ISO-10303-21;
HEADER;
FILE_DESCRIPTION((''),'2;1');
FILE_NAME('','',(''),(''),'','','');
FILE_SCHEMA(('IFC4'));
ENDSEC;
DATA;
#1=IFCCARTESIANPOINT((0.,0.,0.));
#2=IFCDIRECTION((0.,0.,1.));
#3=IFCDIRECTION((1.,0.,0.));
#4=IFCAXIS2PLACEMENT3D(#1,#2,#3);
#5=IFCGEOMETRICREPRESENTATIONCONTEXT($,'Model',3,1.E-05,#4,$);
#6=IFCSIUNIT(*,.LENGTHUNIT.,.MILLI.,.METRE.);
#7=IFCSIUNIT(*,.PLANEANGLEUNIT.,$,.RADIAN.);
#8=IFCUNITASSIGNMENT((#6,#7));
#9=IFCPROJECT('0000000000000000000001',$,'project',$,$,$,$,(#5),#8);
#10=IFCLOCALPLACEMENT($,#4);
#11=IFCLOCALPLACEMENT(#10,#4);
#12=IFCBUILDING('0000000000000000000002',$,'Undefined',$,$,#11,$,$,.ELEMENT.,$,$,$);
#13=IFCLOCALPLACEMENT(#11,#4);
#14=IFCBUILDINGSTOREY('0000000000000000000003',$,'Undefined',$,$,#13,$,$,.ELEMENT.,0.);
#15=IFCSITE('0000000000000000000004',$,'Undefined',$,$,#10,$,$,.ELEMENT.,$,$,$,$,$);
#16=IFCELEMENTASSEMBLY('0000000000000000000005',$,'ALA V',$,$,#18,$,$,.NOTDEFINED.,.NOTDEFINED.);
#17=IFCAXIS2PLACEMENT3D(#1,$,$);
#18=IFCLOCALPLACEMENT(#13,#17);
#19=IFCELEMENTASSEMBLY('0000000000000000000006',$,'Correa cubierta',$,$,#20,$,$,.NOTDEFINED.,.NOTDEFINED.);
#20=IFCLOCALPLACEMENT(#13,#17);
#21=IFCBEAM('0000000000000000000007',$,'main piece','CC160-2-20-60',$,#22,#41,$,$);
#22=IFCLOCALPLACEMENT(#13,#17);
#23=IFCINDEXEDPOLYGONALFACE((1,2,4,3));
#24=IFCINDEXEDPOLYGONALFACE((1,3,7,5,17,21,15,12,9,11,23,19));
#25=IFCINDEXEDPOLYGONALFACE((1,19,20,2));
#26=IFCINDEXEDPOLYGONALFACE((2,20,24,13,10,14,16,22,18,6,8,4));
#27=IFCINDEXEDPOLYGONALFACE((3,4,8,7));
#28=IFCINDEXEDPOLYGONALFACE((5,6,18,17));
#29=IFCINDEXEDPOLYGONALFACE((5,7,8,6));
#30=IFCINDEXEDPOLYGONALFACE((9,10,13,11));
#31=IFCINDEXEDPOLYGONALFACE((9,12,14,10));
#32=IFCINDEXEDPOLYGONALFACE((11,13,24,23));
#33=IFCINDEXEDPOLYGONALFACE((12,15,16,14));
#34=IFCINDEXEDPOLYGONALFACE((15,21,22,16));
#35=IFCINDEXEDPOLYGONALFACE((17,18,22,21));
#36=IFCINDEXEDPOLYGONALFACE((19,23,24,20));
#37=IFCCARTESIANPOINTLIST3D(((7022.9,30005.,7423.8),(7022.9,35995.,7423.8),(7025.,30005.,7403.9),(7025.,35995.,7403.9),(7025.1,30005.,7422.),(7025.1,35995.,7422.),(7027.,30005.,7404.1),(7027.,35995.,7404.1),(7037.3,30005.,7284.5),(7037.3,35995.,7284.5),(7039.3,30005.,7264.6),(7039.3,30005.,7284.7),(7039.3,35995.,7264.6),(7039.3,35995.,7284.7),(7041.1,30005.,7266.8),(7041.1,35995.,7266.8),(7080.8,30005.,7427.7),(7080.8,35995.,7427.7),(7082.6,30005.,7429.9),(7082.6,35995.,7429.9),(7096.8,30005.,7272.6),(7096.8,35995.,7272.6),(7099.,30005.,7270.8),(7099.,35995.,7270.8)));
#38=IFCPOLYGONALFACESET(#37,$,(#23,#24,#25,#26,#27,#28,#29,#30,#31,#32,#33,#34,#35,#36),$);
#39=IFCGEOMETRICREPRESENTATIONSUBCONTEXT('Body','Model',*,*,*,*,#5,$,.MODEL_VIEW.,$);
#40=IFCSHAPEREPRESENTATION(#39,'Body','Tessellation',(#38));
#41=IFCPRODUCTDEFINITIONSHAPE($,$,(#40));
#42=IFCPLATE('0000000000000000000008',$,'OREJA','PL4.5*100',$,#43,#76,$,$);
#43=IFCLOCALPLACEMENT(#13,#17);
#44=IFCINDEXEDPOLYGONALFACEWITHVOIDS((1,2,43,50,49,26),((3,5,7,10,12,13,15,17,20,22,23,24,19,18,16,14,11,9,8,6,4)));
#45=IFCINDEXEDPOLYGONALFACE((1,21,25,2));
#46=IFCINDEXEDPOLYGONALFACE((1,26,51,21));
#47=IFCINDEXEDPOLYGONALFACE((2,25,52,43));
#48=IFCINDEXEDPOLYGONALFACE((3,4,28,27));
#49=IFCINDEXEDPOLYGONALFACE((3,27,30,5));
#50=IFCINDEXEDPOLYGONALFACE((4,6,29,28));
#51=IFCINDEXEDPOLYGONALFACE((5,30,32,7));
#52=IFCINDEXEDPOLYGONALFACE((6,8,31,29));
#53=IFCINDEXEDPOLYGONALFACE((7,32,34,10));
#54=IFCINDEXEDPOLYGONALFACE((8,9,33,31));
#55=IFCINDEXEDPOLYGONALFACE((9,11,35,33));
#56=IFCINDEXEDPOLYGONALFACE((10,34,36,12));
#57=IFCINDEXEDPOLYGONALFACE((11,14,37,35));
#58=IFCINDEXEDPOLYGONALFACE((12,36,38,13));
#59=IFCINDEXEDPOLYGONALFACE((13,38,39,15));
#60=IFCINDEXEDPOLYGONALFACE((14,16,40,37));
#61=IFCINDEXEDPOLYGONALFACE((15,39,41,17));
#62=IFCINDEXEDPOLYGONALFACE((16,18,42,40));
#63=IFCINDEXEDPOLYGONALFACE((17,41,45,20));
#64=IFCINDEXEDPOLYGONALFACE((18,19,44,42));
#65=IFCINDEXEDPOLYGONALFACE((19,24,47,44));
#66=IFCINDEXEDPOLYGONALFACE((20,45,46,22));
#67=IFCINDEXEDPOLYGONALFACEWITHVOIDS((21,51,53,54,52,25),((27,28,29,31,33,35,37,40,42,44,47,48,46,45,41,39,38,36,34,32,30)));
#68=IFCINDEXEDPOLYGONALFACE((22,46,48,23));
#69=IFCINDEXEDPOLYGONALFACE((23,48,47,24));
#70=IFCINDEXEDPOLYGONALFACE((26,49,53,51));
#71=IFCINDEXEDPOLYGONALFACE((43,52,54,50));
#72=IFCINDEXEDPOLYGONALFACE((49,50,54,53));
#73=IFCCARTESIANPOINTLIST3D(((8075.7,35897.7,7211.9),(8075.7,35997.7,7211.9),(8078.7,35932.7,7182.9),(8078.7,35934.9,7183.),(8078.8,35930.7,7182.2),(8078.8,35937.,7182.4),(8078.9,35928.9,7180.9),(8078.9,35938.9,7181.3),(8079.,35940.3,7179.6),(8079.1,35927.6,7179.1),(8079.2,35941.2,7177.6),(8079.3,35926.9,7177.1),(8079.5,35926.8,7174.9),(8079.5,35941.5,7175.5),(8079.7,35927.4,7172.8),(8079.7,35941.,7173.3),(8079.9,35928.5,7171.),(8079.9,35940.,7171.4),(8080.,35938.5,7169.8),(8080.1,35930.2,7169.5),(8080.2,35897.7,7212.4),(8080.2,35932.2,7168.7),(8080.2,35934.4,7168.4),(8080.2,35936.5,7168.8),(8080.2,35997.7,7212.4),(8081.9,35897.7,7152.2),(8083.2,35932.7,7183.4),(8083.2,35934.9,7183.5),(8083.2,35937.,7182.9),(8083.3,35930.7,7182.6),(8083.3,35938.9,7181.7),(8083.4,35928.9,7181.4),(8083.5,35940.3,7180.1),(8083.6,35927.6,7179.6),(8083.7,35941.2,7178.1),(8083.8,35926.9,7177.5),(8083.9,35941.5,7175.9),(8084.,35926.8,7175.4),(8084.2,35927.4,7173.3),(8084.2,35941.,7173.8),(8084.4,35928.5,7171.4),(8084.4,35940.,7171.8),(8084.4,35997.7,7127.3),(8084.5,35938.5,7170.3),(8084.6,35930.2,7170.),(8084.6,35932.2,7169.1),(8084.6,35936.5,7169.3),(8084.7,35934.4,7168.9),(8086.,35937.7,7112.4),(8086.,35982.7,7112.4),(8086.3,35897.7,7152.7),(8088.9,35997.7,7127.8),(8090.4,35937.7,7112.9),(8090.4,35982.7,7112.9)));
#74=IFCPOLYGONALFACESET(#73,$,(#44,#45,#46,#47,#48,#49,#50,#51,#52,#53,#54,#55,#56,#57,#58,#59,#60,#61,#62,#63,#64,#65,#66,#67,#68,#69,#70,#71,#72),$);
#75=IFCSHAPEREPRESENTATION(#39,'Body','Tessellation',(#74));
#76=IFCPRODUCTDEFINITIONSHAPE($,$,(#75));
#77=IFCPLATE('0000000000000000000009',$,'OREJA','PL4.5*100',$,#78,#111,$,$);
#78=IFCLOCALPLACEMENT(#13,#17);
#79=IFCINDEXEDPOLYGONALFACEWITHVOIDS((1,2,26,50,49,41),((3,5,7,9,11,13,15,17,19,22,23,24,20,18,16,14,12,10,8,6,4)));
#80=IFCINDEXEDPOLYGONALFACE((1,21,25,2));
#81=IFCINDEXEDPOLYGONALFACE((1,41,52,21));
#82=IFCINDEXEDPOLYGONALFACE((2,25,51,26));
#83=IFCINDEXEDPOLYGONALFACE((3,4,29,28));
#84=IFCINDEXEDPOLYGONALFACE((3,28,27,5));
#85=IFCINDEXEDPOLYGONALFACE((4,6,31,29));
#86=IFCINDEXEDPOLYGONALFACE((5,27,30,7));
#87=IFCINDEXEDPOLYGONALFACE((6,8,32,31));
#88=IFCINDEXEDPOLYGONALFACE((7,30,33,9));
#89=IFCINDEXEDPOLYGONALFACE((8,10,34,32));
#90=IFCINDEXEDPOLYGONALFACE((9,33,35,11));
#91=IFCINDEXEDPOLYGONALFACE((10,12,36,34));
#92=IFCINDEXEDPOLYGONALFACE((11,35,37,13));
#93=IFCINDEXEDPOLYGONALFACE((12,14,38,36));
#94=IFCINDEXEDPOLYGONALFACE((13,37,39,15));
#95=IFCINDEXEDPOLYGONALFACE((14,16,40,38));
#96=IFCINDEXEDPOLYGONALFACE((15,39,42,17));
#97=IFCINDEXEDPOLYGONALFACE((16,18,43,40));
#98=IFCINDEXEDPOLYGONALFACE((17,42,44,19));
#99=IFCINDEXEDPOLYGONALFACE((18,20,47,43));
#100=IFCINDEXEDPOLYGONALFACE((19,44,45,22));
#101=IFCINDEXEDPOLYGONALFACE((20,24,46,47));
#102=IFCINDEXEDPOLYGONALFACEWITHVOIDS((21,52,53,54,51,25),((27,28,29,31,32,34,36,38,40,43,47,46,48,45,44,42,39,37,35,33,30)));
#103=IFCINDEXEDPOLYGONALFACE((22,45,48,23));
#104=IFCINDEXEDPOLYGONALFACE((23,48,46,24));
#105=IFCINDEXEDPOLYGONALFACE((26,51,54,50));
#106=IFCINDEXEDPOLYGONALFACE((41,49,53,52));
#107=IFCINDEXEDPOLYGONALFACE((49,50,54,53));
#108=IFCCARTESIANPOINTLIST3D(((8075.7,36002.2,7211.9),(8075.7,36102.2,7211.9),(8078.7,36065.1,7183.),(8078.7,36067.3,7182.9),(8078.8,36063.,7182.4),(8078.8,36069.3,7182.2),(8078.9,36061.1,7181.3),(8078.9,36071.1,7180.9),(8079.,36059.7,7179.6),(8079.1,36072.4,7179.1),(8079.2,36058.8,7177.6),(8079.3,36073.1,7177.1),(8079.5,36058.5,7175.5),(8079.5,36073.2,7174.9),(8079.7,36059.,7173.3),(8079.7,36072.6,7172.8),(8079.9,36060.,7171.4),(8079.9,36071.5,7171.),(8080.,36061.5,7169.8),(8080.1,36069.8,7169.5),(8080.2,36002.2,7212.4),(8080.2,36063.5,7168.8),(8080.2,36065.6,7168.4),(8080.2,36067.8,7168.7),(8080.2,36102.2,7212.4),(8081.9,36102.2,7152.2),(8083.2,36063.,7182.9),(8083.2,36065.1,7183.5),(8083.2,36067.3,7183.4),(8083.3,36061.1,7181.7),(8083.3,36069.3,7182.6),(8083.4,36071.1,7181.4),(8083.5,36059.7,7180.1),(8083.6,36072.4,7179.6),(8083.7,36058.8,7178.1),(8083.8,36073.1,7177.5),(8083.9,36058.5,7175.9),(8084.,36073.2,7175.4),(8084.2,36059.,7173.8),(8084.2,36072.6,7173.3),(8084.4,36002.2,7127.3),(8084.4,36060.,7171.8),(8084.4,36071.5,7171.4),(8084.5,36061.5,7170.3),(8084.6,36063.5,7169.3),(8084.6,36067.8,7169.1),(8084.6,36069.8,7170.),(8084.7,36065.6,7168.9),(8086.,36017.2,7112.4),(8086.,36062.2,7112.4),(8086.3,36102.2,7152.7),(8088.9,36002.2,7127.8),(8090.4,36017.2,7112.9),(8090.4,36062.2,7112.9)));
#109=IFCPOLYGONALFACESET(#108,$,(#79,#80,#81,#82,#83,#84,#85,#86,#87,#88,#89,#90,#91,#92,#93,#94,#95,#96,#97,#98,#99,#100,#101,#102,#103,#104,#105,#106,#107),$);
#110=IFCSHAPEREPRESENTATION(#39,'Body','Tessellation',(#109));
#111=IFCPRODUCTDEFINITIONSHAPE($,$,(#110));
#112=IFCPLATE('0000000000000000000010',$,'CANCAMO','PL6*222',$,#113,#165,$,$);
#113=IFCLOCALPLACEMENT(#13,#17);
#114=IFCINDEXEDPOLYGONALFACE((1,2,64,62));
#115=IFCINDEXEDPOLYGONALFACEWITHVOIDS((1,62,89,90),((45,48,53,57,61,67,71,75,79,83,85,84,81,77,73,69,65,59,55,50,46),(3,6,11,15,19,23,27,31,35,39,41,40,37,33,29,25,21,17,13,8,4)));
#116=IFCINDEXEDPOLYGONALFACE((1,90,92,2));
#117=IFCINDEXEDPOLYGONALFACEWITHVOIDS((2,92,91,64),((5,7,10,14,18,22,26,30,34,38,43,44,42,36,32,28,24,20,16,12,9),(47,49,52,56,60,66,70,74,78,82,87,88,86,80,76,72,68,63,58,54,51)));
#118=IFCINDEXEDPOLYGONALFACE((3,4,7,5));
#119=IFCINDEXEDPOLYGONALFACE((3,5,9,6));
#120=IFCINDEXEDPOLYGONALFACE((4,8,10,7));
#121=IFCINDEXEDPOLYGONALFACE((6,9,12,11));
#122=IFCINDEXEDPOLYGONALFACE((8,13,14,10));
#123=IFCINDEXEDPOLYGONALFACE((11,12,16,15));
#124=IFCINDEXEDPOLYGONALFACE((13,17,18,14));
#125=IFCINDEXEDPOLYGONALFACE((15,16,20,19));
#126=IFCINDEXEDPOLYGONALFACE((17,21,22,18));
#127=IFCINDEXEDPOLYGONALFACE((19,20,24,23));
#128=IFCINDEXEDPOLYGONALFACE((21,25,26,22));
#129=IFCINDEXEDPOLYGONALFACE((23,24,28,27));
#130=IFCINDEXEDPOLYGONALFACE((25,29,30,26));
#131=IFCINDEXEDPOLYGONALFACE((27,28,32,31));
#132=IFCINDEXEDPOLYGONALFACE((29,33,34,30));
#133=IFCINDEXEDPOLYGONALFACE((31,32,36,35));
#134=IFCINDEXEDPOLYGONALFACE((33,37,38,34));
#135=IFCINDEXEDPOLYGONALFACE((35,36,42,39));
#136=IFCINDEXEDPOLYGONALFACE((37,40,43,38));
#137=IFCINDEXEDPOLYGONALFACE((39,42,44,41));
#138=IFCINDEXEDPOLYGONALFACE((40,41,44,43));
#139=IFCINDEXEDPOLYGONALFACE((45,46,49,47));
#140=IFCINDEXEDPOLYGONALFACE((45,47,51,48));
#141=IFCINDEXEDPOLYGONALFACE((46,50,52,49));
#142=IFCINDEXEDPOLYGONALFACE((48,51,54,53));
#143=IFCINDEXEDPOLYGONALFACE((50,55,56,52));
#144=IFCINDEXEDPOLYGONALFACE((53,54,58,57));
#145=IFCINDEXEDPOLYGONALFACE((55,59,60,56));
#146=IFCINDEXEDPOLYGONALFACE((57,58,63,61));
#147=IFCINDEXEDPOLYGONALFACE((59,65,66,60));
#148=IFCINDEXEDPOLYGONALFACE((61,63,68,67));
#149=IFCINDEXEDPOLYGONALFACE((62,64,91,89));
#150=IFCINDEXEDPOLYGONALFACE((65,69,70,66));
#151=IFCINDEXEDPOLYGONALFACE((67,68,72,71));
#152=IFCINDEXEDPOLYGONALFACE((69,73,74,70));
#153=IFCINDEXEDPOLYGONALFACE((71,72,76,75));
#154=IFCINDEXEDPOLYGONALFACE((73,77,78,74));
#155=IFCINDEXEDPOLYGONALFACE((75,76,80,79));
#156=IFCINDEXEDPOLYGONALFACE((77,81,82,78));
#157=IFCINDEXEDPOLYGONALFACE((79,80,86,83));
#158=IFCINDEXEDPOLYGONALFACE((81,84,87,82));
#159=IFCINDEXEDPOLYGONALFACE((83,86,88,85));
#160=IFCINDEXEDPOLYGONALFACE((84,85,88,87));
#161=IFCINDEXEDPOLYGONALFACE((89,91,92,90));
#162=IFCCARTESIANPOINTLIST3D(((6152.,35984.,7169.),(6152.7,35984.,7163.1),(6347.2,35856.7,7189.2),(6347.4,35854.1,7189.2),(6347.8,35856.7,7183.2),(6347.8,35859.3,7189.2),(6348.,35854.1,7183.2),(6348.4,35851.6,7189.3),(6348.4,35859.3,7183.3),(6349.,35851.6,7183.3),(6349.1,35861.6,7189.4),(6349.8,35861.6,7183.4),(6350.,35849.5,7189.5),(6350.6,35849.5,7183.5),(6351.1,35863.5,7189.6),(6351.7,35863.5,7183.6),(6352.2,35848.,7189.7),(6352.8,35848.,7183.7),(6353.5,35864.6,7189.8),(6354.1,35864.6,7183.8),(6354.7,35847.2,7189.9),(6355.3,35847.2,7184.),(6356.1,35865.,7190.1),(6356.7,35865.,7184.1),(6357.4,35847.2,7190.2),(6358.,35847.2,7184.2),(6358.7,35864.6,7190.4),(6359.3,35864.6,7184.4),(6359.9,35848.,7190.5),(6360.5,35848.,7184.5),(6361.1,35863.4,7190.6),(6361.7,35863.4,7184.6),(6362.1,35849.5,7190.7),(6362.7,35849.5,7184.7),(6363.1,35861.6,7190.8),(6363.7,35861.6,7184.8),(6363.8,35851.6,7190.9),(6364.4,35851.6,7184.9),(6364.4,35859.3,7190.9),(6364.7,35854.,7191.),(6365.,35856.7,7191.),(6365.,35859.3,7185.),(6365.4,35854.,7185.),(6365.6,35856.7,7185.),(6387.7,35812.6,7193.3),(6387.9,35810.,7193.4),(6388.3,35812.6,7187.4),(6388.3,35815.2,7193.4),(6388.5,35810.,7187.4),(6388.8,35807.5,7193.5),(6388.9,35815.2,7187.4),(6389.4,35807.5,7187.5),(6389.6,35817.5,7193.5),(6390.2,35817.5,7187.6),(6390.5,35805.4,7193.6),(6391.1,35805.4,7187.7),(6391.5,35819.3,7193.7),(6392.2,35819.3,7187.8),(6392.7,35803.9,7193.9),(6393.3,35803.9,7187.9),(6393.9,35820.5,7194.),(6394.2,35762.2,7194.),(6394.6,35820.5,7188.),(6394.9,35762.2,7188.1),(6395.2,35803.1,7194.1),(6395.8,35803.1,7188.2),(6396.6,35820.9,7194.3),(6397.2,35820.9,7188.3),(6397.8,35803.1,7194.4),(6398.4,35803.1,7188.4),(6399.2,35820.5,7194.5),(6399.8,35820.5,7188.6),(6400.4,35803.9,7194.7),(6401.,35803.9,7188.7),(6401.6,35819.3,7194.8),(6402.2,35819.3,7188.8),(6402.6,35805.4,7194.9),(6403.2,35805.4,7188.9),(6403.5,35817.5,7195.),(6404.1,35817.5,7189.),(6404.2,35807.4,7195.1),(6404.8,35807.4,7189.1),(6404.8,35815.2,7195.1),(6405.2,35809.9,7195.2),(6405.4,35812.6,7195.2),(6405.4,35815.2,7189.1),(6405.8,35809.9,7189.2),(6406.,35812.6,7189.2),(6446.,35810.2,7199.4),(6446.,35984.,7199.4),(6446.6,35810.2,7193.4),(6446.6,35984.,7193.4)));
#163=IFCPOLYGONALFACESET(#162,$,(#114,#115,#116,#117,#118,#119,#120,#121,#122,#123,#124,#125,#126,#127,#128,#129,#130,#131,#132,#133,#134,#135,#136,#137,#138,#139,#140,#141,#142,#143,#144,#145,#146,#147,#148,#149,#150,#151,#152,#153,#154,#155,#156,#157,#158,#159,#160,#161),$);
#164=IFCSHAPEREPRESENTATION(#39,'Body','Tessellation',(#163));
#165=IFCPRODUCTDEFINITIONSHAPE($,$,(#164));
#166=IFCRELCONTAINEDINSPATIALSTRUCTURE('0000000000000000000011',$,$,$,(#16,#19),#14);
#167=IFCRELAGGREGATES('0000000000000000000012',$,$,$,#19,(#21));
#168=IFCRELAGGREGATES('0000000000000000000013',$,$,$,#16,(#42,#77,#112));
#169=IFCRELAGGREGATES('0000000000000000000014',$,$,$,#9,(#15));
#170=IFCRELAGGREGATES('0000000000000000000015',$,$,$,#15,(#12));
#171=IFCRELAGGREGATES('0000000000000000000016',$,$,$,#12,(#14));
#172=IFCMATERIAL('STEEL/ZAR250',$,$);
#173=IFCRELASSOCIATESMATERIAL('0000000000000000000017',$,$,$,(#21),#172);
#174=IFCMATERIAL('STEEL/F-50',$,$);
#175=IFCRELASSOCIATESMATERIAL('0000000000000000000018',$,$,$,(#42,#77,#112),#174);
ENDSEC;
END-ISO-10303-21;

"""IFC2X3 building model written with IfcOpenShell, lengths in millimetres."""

from ifc_helpers import new_model, si_unit, frame, origin_with_axes, origin_2d_with_axis, place, context, subcontext, project, spatial, polyline, circle, c_section, outline, extrude, source, transform, mapped, material, element, aggregate, save


model = new_model("IFC2X3")

# Units and contexts
model_context = context("Model", 3, precision=1e-05, world=origin_with_axes())
body_context = subcontext(model_context, "Body", "Model", "MODEL_VIEW")
ifc_project = project(units=[si_unit("LENGTHUNIT", "METRE", prefix="MILLI"), si_unit("PLANEANGLEUNIT", "RADIAN")], contexts=[model_context])

# Site, building, storey
site_placement = place(None, origin_with_axes())
site = spatial("IfcSite", under=ifc_project, at=site_placement, Name="Undefined", CompositionType="ELEMENT")
building_placement = place(site_placement, origin_with_axes())
building = spatial("IfcBuilding", under=site, at=building_placement, Name="Undefined", CompositionType="ELEMENT")
storey_placement = place(building_placement, origin_with_axes())
storey = spatial("IfcBuildingStorey", under=building, at=storey_placement, Name="Undefined", CompositionType="ELEMENT", Elevation=0.0)

# Element assembly
assembly_1_placement = place(storey_placement, origin_with_axes())
assembly_1 = element("IfcElementAssembly", 1, at=assembly_1_placement, inside=storey, Name="ALA V", AssemblyPlace="NOTDEFINED", PredefinedType="NOTDEFINED")
ifc_material_1 = material(Name="STEEL/F-50")

# Element assembly, beam
ifc_material_2 = material(Name="STEEL/ZAR250")
assembly_2_placement = place(storey_placement, origin_with_axes())
assembly_2 = element("IfcElementAssembly", 2, at=assembly_2_placement, inside=storey, Name="Correa cubierta", AssemblyPlace="NOTDEFINED", PredefinedType="NOTDEFINED")
beam_1_placement = place(assembly_2_placement, frame((7061.0, 35995.0, 7347.3), z_axis=(-0.102562, 0.0, 0.994727), x_axis=(0.0, -1.0, 0.0)))
beam_1 = element("IfcBeam", 3, at=beam_1_placement, material=ifc_material_2, Name="main piece", Description="CC160-2-20-60", context=body_context, shape_type="SweptSolid", body=[
    extrude(c_section(Depth=160.0, Width=60.0, WallThickness=2.0, Girth=20.0, at=origin_2d_with_axis()), frame((5990.0, 0.0, 0.0), z_axis=(-1.0, 0.0, 0.0), x_axis=(0.0, -1.0, 0.0)), (0.0, 0.0, 1.0), 5990.0),
])
aggregate(assembly_2, [beam_1])

# Plates, openings
plate_1_placement = place(assembly_1_placement, frame((8088.2, 35997.7, 7112.7), z_axis=(-0.994727, 0.0, -0.102562), x_axis=(0.0, -1.0, 0.0)))
plate_1 = element("IfcPlate", 4, at=plate_1_placement, material=ifc_material_1, Name="OREJA", Description="PL4.5*100", context=body_context, shape_type="SweptSolid", body=[
    extrude(outline(polyline([(0.0, 15.0), (15.0, 0.0), (60.0, 0.0), (100.0, 40.0), (100.0, 100.0), (0.0, 100.0), (0.0, 15.0)])), frame((0.0, 0.0, -2.2), z_axis=(0.0, 0.0, 1.0), x_axis=(1.0, 0.0, 0.0)), (0.0, 0.0, 1.0), 4.5),
])
shared_shape_1 = source(origin_with_axes(), body_context, "Body", "SweptSolid", [
    extrude(circle(Radius=7.3, at=origin_2d_with_axis()), frame((0.0, -0.1, 0.0), z_axis=(0.0, 1.0, 0.0), x_axis=(1.0, 0.0, 0.0)), (0.0, 0.0, 1.0), 4.7),
])
opening_1_placement = place(assembly_1_placement, frame((8083.9, 35934.1, 7176.2), z_axis=(0.072522, -0.707107, -0.703378), x_axis=(-0.072522, -0.707107, 0.703378)))
element("IfcOpeningElement", 5, at=opening_1_placement, cuts=plate_1, ObjectType="Opening", context=body_context, shape_type="MappedRepresentation", body=[
    mapped(shared_shape_1, transform((0.0, 0.0, 0.0))),
])
plate_2_placement = place(assembly_1_placement, frame((8088.2, 36002.2, 7112.7), z_axis=(0.994727, 0.0, 0.102562), x_axis=(0.0, 1.0, 0.0)))
plate_2 = element("IfcPlate", 6, at=plate_2_placement, material=ifc_material_1, Name="OREJA", Description="PL4.5*100", context=body_context, shape_type="SweptSolid", body=[
    extrude(outline(polyline([(0.0, 15.0), (15.0, 0.0), (60.0, 0.0), (100.0, 40.0), (100.0, 100.0), (0.0, 100.0), (0.0, 15.0)])), frame((0.0, 0.0, -2.2), z_axis=(0.0, 0.0, 1.0), x_axis=(1.0, 0.0, 0.0)), (0.0, 0.0, 1.0), 4.5),
])
opening_2_placement = place(assembly_1_placement, frame((8083.9, 36065.9, 7176.2), z_axis=(-0.072522, -0.707107, 0.703378), x_axis=(-0.072522, 0.707107, 0.703378)))
element("IfcOpeningElement", 7, at=opening_2_placement, cuts=plate_2, ObjectType="Opening", context=body_context, shape_type="MappedRepresentation", body=[
    mapped(shared_shape_1, transform((0.0, 0.0, 0.0))),
])
plate_3_placement = place(assembly_1_placement, frame((6446.3, 35984.0, 7196.4), z_axis=(-0.102676, 0.0, 0.994715), x_axis=(-0.994715, 0.0, -0.102675)))
plate_3 = element("IfcPlate", 8, at=plate_3_placement, material=ifc_material_1, Name="CANCAMO", Description="PL6*222", context=body_context, shape_type="SweptSolid", body=[
    extrude(outline(polyline([(0.0, 0.0), (295.5, 0.0), (52.1, 221.8), (0.0, 173.8), (0.0, 0.0)])), frame((0.0, 0.0, -3.0), z_axis=(0.0, 0.0, 1.0), x_axis=(1.0, 0.0, 0.0)), (0.0, 0.0, 1.0), 6.0),
])
shared_shape_2 = source(origin_with_axes(), body_context, "Body", "SweptSolid", [
    extrude(circle(Radius=8.9, at=origin_2d_with_axis()), frame((0.0, -0.1, 0.0), z_axis=(0.0, 1.0, 0.0), x_axis=(1.0, 0.0, 0.0)), (0.0, 0.0, 1.0), 6.2),
])
opening_3_placement = place(assembly_1_placement, frame((6356.1, 35856.1, 7190.1), z_axis=(0.731384, 0.677774, 0.075494), x_axis=(0.674192, -0.73527, 0.069591)))
element("IfcOpeningElement", 9, at=opening_3_placement, cuts=plate_3, ObjectType="Opening", context=body_context, shape_type="MappedRepresentation", body=[
    mapped(shared_shape_2, transform((0.0, 0.0, 0.0))),
    mapped(shared_shape_2, transform((60.0, 0.0, 0.0))),
])

aggregate(assembly_1, [plate_1, plate_2, plate_3])

save(model, "model.ifc")
